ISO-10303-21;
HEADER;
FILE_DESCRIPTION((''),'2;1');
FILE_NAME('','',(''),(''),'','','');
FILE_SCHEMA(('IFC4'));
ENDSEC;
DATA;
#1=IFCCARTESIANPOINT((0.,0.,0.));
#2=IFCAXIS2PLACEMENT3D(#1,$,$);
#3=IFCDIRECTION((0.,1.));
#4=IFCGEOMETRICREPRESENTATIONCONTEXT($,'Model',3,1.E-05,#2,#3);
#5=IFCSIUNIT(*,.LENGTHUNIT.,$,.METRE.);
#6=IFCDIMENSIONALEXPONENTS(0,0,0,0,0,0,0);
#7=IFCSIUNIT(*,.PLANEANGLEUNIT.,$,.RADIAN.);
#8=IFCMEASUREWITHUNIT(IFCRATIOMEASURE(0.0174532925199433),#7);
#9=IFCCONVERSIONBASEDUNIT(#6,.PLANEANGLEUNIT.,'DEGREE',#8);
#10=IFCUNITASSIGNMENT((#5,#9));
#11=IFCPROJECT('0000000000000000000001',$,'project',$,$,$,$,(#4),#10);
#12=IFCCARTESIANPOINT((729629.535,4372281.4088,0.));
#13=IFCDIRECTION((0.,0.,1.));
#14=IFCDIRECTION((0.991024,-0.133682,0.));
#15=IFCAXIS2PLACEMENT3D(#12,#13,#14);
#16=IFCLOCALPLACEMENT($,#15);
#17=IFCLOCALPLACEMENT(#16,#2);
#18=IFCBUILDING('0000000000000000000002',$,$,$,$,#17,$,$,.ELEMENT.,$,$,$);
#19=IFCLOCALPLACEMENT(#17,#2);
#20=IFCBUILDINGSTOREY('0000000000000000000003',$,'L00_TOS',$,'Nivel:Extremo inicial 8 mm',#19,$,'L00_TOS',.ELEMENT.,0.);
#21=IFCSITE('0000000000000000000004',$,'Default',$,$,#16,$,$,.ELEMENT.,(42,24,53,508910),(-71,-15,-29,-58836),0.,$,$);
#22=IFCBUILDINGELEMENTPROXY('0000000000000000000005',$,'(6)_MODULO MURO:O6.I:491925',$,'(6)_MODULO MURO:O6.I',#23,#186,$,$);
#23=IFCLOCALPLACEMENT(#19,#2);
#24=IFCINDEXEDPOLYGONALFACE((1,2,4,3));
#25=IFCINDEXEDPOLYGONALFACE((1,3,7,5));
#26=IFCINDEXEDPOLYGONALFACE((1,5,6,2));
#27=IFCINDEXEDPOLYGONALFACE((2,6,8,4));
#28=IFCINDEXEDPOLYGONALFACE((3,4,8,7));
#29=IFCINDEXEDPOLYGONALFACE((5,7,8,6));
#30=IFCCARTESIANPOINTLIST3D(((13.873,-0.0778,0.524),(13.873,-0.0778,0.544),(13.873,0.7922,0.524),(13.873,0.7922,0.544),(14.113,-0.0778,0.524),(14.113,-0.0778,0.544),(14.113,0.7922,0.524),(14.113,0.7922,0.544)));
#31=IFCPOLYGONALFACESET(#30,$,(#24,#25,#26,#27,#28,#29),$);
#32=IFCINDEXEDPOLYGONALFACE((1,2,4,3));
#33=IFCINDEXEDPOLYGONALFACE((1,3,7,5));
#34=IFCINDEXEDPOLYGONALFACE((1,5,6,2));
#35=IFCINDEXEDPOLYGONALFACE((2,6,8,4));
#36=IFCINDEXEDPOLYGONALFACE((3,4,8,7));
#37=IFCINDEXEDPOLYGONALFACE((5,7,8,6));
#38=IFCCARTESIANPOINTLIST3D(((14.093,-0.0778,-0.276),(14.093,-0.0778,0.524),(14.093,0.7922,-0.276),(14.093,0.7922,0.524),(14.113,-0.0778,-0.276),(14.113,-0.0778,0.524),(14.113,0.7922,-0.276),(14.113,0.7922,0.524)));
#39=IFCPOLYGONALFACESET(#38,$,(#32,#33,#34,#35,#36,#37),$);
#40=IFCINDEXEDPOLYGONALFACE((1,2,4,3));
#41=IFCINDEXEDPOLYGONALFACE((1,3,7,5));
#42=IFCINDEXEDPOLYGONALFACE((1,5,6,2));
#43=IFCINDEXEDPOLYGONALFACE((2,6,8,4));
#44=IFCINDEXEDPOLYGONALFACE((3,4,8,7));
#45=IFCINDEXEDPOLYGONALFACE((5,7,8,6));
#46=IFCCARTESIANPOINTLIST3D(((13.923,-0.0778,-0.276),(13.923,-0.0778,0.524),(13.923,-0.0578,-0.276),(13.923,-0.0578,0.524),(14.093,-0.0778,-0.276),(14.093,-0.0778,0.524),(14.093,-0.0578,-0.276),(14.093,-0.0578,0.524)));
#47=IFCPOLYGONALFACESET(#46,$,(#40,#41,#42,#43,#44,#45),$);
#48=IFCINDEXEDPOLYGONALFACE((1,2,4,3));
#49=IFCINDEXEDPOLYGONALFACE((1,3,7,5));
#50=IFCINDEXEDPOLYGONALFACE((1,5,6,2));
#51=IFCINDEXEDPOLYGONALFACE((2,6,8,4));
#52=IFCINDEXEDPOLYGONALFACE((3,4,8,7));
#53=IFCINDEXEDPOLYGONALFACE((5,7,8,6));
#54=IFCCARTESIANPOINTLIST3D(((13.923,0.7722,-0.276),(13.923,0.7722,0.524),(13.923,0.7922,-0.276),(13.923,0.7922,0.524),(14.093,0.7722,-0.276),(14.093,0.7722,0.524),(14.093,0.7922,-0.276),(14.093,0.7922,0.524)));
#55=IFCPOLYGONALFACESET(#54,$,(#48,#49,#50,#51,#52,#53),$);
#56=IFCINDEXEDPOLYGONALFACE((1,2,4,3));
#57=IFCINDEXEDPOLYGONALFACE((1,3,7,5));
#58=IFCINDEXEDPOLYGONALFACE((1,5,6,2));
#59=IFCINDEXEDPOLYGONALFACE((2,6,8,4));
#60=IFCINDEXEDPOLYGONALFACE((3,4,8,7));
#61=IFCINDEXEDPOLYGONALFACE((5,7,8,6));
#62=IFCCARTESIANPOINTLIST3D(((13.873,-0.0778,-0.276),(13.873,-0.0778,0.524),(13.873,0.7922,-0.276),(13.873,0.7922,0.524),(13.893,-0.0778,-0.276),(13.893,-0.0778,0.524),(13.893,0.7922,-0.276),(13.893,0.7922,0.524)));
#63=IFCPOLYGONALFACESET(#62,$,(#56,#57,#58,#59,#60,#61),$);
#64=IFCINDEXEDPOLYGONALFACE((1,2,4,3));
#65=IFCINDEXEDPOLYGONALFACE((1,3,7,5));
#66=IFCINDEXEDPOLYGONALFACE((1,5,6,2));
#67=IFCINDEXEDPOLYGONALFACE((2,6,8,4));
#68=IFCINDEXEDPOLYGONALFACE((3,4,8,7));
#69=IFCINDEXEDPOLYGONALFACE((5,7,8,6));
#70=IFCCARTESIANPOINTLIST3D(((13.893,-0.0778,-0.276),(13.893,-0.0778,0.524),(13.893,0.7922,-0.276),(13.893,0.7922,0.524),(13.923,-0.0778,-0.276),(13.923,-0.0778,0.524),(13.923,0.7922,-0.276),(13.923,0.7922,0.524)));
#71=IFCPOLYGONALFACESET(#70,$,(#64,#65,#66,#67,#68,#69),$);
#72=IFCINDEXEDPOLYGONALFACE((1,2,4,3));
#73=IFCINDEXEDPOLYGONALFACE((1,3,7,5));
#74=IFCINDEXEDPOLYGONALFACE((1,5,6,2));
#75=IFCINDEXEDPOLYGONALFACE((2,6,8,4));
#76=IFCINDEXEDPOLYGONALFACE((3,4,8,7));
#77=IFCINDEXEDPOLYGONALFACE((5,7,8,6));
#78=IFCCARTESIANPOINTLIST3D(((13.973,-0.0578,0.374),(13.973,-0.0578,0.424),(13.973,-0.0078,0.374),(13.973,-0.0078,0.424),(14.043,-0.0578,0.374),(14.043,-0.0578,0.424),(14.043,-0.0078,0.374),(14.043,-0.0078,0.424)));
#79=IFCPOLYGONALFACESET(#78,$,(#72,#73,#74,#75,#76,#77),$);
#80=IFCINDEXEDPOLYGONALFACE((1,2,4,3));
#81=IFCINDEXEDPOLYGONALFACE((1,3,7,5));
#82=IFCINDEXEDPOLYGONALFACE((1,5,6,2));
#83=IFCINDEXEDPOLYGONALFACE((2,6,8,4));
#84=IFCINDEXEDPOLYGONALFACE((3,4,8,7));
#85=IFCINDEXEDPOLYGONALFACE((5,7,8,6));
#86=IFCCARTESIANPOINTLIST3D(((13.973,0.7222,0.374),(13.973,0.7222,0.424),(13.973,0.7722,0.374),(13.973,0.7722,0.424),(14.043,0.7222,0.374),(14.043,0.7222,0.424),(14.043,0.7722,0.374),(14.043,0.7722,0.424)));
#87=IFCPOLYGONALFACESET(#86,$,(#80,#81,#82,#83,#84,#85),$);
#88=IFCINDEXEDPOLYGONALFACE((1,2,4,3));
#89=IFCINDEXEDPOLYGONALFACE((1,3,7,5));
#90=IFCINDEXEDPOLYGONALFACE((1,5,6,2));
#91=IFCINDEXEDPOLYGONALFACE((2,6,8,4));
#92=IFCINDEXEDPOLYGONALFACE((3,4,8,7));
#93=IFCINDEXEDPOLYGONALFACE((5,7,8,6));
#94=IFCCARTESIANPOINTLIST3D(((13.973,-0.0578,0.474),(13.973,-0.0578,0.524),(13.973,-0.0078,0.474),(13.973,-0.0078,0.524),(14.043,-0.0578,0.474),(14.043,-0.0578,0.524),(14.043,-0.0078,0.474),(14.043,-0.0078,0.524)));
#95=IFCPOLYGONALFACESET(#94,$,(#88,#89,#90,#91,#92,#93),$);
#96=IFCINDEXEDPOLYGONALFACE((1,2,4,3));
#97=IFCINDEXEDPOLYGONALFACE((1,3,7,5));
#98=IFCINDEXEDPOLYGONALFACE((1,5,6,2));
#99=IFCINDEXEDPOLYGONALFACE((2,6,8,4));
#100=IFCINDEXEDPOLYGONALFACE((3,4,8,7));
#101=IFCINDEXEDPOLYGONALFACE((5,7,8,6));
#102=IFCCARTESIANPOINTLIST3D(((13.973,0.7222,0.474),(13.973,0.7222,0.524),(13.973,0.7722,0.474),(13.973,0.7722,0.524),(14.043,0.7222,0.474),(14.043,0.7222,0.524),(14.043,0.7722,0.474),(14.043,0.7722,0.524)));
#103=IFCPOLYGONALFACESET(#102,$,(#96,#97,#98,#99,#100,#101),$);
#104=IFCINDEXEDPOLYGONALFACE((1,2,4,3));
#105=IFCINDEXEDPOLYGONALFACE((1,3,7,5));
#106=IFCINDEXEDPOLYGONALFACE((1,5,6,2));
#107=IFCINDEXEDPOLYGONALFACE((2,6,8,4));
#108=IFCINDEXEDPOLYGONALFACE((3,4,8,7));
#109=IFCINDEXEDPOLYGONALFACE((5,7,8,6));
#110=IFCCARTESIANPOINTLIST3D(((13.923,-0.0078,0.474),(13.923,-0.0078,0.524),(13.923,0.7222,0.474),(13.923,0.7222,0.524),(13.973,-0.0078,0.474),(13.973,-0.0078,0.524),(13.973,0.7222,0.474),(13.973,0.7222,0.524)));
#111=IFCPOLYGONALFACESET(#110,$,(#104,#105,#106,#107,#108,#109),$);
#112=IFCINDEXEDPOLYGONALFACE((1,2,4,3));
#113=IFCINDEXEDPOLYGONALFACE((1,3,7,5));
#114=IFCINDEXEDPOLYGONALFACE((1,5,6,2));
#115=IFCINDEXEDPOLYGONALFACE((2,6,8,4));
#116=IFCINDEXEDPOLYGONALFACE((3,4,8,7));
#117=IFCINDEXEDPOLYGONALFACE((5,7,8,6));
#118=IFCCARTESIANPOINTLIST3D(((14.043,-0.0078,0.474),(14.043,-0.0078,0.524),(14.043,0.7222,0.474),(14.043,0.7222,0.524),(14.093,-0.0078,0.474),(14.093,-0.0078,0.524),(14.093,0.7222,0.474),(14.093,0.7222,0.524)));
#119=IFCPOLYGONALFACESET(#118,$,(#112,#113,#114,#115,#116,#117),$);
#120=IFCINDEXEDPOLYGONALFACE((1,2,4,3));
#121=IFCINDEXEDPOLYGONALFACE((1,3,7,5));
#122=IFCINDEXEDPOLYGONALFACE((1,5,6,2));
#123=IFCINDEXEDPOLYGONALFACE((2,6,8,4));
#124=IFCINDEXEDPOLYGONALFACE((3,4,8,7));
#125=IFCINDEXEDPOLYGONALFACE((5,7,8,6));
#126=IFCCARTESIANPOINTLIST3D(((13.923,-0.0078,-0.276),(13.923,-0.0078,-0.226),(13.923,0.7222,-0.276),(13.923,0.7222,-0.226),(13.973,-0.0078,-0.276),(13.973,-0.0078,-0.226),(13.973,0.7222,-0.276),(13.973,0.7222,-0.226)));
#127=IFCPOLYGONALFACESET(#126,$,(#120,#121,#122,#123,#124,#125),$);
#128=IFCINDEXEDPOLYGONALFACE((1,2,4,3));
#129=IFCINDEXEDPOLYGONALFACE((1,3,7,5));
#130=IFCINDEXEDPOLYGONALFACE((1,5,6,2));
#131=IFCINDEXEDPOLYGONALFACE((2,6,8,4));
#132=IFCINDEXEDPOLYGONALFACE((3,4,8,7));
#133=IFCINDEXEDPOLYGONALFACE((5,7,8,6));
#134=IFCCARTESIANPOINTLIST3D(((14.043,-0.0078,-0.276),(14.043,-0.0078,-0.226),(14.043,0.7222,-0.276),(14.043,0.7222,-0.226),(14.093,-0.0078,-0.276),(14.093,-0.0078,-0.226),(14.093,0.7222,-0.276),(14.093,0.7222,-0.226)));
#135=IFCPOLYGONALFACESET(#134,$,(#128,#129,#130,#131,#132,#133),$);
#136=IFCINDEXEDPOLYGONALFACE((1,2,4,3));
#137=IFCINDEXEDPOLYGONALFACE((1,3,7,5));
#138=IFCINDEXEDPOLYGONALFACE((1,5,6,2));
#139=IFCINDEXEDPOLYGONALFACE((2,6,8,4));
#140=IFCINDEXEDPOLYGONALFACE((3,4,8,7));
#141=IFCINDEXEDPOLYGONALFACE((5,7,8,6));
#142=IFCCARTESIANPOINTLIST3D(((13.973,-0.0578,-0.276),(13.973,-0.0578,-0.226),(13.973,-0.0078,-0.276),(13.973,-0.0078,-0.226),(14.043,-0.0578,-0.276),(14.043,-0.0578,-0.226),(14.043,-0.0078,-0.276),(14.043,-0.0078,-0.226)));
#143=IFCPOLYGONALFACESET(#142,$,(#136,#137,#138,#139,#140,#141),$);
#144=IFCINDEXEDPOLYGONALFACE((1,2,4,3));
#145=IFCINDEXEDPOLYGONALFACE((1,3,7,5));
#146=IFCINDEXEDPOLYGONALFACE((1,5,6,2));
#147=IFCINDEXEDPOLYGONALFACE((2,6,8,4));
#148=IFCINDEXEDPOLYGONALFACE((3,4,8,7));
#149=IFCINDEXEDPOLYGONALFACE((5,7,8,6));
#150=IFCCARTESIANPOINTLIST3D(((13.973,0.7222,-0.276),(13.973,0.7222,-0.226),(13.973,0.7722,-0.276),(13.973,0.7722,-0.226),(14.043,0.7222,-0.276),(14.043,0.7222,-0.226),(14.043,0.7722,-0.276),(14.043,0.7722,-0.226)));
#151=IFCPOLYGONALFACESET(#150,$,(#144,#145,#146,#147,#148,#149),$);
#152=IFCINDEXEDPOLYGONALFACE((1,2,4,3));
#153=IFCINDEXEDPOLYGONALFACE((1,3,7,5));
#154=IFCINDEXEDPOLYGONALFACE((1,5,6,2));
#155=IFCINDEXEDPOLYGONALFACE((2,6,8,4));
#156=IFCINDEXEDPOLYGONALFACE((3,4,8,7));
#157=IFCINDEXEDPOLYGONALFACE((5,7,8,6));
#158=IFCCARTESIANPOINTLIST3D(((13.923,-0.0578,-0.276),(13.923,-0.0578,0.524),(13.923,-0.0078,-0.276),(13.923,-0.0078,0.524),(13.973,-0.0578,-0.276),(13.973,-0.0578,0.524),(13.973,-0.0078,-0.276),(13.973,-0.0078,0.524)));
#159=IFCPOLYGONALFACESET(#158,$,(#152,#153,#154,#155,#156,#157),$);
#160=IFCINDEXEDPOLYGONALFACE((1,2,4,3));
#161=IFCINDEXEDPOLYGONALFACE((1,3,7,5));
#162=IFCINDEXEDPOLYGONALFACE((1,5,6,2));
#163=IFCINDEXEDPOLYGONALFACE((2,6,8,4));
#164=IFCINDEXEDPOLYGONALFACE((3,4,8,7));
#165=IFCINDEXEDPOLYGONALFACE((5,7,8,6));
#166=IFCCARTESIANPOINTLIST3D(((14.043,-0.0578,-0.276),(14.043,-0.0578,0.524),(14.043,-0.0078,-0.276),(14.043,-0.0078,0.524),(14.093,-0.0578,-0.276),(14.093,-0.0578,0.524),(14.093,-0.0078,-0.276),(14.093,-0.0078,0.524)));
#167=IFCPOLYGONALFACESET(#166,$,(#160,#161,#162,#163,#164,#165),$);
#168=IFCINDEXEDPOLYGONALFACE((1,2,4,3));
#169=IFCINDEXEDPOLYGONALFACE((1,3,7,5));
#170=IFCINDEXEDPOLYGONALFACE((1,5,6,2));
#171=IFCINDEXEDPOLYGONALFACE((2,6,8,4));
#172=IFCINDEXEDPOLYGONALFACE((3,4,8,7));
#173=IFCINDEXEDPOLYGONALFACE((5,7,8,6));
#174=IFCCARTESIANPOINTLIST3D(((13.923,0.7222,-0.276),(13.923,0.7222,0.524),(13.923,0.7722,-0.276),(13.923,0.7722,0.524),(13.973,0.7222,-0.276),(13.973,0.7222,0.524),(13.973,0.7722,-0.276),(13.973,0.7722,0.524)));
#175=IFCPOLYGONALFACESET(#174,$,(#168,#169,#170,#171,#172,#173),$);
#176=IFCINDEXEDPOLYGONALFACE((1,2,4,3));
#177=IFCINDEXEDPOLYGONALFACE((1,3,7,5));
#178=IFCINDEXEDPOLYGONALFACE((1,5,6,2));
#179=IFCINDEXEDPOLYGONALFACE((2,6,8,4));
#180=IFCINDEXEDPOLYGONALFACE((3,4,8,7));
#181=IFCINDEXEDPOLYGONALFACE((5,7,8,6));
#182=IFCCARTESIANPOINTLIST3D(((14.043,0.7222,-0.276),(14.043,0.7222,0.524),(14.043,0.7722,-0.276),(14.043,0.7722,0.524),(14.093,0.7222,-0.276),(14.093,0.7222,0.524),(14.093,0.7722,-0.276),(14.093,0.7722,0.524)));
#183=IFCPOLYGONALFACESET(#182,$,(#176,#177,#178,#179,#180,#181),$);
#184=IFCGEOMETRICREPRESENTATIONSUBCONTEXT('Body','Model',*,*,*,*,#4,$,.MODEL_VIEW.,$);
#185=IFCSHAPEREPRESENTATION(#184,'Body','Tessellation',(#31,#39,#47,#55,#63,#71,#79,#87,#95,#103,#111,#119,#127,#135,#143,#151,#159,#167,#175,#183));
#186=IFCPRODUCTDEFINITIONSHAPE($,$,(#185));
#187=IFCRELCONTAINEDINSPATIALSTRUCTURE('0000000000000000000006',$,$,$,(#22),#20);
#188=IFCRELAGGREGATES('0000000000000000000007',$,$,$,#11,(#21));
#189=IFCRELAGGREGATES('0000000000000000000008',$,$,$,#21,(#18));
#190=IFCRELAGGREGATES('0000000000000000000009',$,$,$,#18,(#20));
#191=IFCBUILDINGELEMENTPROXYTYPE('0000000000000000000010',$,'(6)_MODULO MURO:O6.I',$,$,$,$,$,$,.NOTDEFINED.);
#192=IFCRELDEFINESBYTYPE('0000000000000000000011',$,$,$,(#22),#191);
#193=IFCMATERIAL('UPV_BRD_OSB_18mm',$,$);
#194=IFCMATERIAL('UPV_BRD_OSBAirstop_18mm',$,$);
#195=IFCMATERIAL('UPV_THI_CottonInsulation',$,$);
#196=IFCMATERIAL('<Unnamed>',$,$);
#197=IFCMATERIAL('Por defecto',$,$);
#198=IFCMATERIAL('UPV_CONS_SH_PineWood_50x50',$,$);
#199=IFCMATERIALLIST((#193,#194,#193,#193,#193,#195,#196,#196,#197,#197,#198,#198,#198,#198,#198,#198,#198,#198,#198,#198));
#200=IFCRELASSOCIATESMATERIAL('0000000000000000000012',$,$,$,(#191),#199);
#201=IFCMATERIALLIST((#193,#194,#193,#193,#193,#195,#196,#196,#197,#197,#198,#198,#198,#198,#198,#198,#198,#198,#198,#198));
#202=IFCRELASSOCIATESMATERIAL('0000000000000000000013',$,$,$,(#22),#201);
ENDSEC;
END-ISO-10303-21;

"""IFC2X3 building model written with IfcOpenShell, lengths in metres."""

from ifc_helpers import new_model, entity, si_unit, converted_unit, direction, frame, frame_2d, origin, origin_2d_with_axis, place, context, subcontext, project, spatial, rectangle, extrude, source, transform, mapped, material, material_list, type_object, type_shapes, element, save


model = new_model("IFC2X3")

# Units and contexts
model_context = context("Model", 3, precision=1e-05, world=origin(), true_north=direction((0.0, 1.0)))
body_context = subcontext(model_context, "Body", "Model", "MODEL_VIEW")
ifc_project = project(units=[si_unit("LENGTHUNIT", "METRE"), converted_unit("PLANEANGLEUNIT", "DEGREE", entity("IfcRatioMeasure", 0.0174532925199433), si_unit("PLANEANGLEUNIT", "RADIAN"), dimensions=[0, 0, 0, 0, 0, 0, 0])], contexts=[model_context])

# Site, building, storey
site_placement = place(None, frame((729629.535, 4372281.4088, 0.0), z_axis=(0.0, 0.0, 1.0), x_axis=(0.991024, -0.133682, 0.0)))
site = spatial("IfcSite", under=ifc_project, at=site_placement, Name="Default", CompositionType="ELEMENT", RefLatitude=(42, 24, 53, 508910), RefLongitude=(-71, -15, -29, -58836), RefElevation=0.0)
building_placement = place(site_placement, origin())
building = spatial("IfcBuilding", under=site, at=building_placement, CompositionType="ELEMENT")
storey_placement = place(building_placement, origin())
storey = spatial("IfcBuildingStorey", under=building, at=storey_placement, Name="L00_TOS", ObjectType="Nivel:Extremo inicial 8 mm", LongName="L00_TOS", CompositionType="ELEMENT", Elevation=0.0)

# Building element proxy
ifc_material_1 = material(Name="UPV_BRD_OSBAirstop_18mm")
ifc_material_2 = material(Name="UPV_BRD_OSB_18mm")
ifc_material_3 = material(Name="UPV_THI_CottonInsulation")
ifc_material_4 = material(Name="<Unnamed>")
ifc_material_5 = material(Name="UPV_CONS_SH_PineWood_50x50")
ifc_material_6 = material(Name="Por defecto")
ifc_material_list_1 = material_list([ifc_material_2, ifc_material_1, ifc_material_2, ifc_material_2, ifc_material_2, ifc_material_3, ifc_material_4, ifc_material_4, ifc_material_6, ifc_material_6, ifc_material_5, ifc_material_5, ifc_material_5, ifc_material_5, ifc_material_5, ifc_material_5, ifc_material_5, ifc_material_5, ifc_material_5, ifc_material_5])
ifc_material_list_2 = material_list([ifc_material_2, ifc_material_1, ifc_material_2, ifc_material_2, ifc_material_2, ifc_material_3, ifc_material_4, ifc_material_4, ifc_material_6, ifc_material_6, ifc_material_5, ifc_material_5, ifc_material_5, ifc_material_5, ifc_material_5, ifc_material_5, ifc_material_5, ifc_material_5, ifc_material_5, ifc_material_5])
building_element_proxy_type_1 = type_object("IfcBuildingElementProxyType", Name="(6)_MODULO MURO:O6.I", PredefinedType="NOTDEFINED", material=ifc_material_list_2)
shared_shape_1 = source(origin(), body_context, "Body", "SweptSolid", [
    extrude(rectangle(XDim=0.87, YDim=0.24, at=origin_2d_with_axis()), frame((0.0, 0.015, 0.8), z_axis=(0.0, 0.0, 1.0), x_axis=(-1.0, 0.0, 0.0)), (0.0, 0.0, 1.0), 0.02),
    extrude(rectangle(XDim=0.87, YDim=0.02, at=origin_2d_with_axis()), frame((0.0, -0.095, 0.0)), (0.0, 0.0, 1.0), 0.8),
    extrude(rectangle(XDim=0.17, YDim=0.02, at=frame_2d((0.0, 0.0), x_axis=(1.0, 0.0))), frame((-0.425, 0.0, 0.0), z_axis=(0.0, 0.0, 1.0), x_axis=(0.0, -1.0, 0.0)), (0.0, 0.0, 1.0), 0.8),
    extrude(rectangle(XDim=0.17, YDim=0.02, at=origin_2d_with_axis()), frame((0.425, 0.0, 0.0), z_axis=(0.0, 0.0, 1.0), x_axis=(0.0, -1.0, 0.0)), (0.0, 0.0, 1.0), 0.8),
    extrude(rectangle(XDim=0.87, YDim=0.02, at=origin_2d_with_axis()), frame((0.0, 0.125, 0.0), z_axis=(0.0, 0.0, 1.0), x_axis=(-1.0, 0.0, 0.0)), (0.0, 0.0, 1.0), 0.8),
    extrude(rectangle(XDim=0.87, YDim=0.03, at=origin_2d_with_axis()), frame((0.0, 0.1, 0.0), z_axis=(0.0, 0.0, 1.0), x_axis=(-1.0, 0.0, 0.0)), (0.0, 0.0, 1.0), 0.8),
    extrude(rectangle(XDim=0.07, YDim=0.05, at=origin_2d_with_axis()), frame((-0.39, 0.0, 0.65), z_axis=(0.0, 0.0, 1.0), x_axis=(0.0, 1.0, 0.0)), (0.0, 0.0, 1.0), 0.05),
    extrude(rectangle(XDim=0.07, YDim=0.05, at=origin_2d_with_axis()), frame((0.39, 0.0, 0.65), z_axis=(0.0, 0.0, 1.0), x_axis=(0.0, 1.0, 0.0)), (0.0, 0.0, 1.0), 0.05),
    extrude(rectangle(XDim=0.07, YDim=0.05, at=origin_2d_with_axis()), frame((-0.39, 0.0, 0.75), z_axis=(0.0, 0.0, 1.0), x_axis=(0.0, -1.0, 0.0)), (0.0, 0.0, 1.0), 0.05),
    extrude(rectangle(XDim=0.07, YDim=0.05, at=frame_2d((0.0, 0.0), x_axis=(1.0, 0.0))), frame((0.39, 0.0, 0.75), z_axis=(0.0, 0.0, 1.0), x_axis=(0.0, -1.0, 0.0)), (0.0, 0.0, 1.0), 0.05),
    extrude(rectangle(XDim=0.73, YDim=0.05, at=origin_2d_with_axis()), frame((0.0, 0.06, 0.75), z_axis=(0.0, 0.0, 1.0), x_axis=(-1.0, 0.0, 0.0)), (0.0, 0.0, 1.0), 0.05),
    extrude(rectangle(XDim=0.05, YDim=0.73, at=origin_2d_with_axis()), frame((0.0, -0.06, 0.75), z_axis=(0.0, 0.0, 1.0), x_axis=(0.0, -1.0, 0.0)), (0.0, 0.0, 1.0), 0.05),
    extrude(rectangle(XDim=0.05, YDim=0.73, at=origin_2d_with_axis()), frame((0.0, 0.06, 0.0), z_axis=(0.0, 0.0, 1.0), x_axis=(0.0, -1.0, 0.0)), (0.0, 0.0, 1.0), 0.05),
    extrude(rectangle(XDim=0.05, YDim=0.73, at=origin_2d_with_axis()), frame((0.0, -0.06, 0.0), z_axis=(0.0, 0.0, 1.0), x_axis=(0.0, -1.0, 0.0)), (0.0, 0.0, 1.0), 0.05),
    extrude(rectangle(XDim=0.07, YDim=0.05, at=origin_2d_with_axis()), frame((-0.39, 0.0, 0.0), z_axis=(0.0, 0.0, 1.0), x_axis=(0.0, -1.0, 0.0)), (0.0, 0.0, 1.0), 0.05),
    extrude(rectangle(XDim=0.05, YDim=0.07, at=origin_2d_with_axis()), frame((0.39, 0.0, 0.0), z_axis=(0.0, 0.0, 1.0), x_axis=(-1.0, 0.0, 0.0)), (0.0, 0.0, 1.0), 0.05),
    extrude(rectangle(XDim=0.05, YDim=0.05, at=origin_2d_with_axis()), frame((-0.39, 0.06, 0.0), z_axis=(0.0, 0.0, 1.0), x_axis=(0.0, -1.0, 0.0)), (0.0, 0.0, 1.0), 0.8),
    extrude(rectangle(XDim=0.05, YDim=0.05, at=origin_2d_with_axis()), frame((-0.39, -0.06, 0.0), z_axis=(0.0, 0.0, 1.0), x_axis=(0.0, -1.0, 0.0)), (0.0, 0.0, 1.0), 0.8),
    extrude(rectangle(XDim=0.05, YDim=0.05, at=origin_2d_with_axis()), frame((0.39, 0.06, 0.0), z_axis=(0.0, 0.0, 1.0), x_axis=(0.0, -1.0, 0.0)), (0.0, 0.0, 1.0), 0.8),
    extrude(rectangle(XDim=0.05, YDim=0.05, at=origin_2d_with_axis()), frame((0.39, -0.06, 0.0), z_axis=(0.0, 0.0, 1.0), x_axis=(0.0, -1.0, 0.0)), (0.0, 0.0, 1.0), 0.8),
])
type_shapes(building_element_proxy_type_1, [shared_shape_1])
proxy_1_placement = place(storey_placement, frame((14.008, 0.3572, -0.276), z_axis=(0.0, 0.0, 1.0), x_axis=(0.0, 1.0, 0.0)))
element("IfcBuildingElementProxy", 1, at=proxy_1_placement, inside=storey, type_object=building_element_proxy_type_1, material=ifc_material_list_1, Name="(6)_MODULO MURO:O6.I:491925", ObjectType="(6)_MODULO MURO:O6.I", context=body_context, shape_type="MappedRepresentation", body=[
    mapped(shared_shape_1, transform((0.0, 0.0, 0.0), scale=1.0)),
])

save(model, "model.ifc")
